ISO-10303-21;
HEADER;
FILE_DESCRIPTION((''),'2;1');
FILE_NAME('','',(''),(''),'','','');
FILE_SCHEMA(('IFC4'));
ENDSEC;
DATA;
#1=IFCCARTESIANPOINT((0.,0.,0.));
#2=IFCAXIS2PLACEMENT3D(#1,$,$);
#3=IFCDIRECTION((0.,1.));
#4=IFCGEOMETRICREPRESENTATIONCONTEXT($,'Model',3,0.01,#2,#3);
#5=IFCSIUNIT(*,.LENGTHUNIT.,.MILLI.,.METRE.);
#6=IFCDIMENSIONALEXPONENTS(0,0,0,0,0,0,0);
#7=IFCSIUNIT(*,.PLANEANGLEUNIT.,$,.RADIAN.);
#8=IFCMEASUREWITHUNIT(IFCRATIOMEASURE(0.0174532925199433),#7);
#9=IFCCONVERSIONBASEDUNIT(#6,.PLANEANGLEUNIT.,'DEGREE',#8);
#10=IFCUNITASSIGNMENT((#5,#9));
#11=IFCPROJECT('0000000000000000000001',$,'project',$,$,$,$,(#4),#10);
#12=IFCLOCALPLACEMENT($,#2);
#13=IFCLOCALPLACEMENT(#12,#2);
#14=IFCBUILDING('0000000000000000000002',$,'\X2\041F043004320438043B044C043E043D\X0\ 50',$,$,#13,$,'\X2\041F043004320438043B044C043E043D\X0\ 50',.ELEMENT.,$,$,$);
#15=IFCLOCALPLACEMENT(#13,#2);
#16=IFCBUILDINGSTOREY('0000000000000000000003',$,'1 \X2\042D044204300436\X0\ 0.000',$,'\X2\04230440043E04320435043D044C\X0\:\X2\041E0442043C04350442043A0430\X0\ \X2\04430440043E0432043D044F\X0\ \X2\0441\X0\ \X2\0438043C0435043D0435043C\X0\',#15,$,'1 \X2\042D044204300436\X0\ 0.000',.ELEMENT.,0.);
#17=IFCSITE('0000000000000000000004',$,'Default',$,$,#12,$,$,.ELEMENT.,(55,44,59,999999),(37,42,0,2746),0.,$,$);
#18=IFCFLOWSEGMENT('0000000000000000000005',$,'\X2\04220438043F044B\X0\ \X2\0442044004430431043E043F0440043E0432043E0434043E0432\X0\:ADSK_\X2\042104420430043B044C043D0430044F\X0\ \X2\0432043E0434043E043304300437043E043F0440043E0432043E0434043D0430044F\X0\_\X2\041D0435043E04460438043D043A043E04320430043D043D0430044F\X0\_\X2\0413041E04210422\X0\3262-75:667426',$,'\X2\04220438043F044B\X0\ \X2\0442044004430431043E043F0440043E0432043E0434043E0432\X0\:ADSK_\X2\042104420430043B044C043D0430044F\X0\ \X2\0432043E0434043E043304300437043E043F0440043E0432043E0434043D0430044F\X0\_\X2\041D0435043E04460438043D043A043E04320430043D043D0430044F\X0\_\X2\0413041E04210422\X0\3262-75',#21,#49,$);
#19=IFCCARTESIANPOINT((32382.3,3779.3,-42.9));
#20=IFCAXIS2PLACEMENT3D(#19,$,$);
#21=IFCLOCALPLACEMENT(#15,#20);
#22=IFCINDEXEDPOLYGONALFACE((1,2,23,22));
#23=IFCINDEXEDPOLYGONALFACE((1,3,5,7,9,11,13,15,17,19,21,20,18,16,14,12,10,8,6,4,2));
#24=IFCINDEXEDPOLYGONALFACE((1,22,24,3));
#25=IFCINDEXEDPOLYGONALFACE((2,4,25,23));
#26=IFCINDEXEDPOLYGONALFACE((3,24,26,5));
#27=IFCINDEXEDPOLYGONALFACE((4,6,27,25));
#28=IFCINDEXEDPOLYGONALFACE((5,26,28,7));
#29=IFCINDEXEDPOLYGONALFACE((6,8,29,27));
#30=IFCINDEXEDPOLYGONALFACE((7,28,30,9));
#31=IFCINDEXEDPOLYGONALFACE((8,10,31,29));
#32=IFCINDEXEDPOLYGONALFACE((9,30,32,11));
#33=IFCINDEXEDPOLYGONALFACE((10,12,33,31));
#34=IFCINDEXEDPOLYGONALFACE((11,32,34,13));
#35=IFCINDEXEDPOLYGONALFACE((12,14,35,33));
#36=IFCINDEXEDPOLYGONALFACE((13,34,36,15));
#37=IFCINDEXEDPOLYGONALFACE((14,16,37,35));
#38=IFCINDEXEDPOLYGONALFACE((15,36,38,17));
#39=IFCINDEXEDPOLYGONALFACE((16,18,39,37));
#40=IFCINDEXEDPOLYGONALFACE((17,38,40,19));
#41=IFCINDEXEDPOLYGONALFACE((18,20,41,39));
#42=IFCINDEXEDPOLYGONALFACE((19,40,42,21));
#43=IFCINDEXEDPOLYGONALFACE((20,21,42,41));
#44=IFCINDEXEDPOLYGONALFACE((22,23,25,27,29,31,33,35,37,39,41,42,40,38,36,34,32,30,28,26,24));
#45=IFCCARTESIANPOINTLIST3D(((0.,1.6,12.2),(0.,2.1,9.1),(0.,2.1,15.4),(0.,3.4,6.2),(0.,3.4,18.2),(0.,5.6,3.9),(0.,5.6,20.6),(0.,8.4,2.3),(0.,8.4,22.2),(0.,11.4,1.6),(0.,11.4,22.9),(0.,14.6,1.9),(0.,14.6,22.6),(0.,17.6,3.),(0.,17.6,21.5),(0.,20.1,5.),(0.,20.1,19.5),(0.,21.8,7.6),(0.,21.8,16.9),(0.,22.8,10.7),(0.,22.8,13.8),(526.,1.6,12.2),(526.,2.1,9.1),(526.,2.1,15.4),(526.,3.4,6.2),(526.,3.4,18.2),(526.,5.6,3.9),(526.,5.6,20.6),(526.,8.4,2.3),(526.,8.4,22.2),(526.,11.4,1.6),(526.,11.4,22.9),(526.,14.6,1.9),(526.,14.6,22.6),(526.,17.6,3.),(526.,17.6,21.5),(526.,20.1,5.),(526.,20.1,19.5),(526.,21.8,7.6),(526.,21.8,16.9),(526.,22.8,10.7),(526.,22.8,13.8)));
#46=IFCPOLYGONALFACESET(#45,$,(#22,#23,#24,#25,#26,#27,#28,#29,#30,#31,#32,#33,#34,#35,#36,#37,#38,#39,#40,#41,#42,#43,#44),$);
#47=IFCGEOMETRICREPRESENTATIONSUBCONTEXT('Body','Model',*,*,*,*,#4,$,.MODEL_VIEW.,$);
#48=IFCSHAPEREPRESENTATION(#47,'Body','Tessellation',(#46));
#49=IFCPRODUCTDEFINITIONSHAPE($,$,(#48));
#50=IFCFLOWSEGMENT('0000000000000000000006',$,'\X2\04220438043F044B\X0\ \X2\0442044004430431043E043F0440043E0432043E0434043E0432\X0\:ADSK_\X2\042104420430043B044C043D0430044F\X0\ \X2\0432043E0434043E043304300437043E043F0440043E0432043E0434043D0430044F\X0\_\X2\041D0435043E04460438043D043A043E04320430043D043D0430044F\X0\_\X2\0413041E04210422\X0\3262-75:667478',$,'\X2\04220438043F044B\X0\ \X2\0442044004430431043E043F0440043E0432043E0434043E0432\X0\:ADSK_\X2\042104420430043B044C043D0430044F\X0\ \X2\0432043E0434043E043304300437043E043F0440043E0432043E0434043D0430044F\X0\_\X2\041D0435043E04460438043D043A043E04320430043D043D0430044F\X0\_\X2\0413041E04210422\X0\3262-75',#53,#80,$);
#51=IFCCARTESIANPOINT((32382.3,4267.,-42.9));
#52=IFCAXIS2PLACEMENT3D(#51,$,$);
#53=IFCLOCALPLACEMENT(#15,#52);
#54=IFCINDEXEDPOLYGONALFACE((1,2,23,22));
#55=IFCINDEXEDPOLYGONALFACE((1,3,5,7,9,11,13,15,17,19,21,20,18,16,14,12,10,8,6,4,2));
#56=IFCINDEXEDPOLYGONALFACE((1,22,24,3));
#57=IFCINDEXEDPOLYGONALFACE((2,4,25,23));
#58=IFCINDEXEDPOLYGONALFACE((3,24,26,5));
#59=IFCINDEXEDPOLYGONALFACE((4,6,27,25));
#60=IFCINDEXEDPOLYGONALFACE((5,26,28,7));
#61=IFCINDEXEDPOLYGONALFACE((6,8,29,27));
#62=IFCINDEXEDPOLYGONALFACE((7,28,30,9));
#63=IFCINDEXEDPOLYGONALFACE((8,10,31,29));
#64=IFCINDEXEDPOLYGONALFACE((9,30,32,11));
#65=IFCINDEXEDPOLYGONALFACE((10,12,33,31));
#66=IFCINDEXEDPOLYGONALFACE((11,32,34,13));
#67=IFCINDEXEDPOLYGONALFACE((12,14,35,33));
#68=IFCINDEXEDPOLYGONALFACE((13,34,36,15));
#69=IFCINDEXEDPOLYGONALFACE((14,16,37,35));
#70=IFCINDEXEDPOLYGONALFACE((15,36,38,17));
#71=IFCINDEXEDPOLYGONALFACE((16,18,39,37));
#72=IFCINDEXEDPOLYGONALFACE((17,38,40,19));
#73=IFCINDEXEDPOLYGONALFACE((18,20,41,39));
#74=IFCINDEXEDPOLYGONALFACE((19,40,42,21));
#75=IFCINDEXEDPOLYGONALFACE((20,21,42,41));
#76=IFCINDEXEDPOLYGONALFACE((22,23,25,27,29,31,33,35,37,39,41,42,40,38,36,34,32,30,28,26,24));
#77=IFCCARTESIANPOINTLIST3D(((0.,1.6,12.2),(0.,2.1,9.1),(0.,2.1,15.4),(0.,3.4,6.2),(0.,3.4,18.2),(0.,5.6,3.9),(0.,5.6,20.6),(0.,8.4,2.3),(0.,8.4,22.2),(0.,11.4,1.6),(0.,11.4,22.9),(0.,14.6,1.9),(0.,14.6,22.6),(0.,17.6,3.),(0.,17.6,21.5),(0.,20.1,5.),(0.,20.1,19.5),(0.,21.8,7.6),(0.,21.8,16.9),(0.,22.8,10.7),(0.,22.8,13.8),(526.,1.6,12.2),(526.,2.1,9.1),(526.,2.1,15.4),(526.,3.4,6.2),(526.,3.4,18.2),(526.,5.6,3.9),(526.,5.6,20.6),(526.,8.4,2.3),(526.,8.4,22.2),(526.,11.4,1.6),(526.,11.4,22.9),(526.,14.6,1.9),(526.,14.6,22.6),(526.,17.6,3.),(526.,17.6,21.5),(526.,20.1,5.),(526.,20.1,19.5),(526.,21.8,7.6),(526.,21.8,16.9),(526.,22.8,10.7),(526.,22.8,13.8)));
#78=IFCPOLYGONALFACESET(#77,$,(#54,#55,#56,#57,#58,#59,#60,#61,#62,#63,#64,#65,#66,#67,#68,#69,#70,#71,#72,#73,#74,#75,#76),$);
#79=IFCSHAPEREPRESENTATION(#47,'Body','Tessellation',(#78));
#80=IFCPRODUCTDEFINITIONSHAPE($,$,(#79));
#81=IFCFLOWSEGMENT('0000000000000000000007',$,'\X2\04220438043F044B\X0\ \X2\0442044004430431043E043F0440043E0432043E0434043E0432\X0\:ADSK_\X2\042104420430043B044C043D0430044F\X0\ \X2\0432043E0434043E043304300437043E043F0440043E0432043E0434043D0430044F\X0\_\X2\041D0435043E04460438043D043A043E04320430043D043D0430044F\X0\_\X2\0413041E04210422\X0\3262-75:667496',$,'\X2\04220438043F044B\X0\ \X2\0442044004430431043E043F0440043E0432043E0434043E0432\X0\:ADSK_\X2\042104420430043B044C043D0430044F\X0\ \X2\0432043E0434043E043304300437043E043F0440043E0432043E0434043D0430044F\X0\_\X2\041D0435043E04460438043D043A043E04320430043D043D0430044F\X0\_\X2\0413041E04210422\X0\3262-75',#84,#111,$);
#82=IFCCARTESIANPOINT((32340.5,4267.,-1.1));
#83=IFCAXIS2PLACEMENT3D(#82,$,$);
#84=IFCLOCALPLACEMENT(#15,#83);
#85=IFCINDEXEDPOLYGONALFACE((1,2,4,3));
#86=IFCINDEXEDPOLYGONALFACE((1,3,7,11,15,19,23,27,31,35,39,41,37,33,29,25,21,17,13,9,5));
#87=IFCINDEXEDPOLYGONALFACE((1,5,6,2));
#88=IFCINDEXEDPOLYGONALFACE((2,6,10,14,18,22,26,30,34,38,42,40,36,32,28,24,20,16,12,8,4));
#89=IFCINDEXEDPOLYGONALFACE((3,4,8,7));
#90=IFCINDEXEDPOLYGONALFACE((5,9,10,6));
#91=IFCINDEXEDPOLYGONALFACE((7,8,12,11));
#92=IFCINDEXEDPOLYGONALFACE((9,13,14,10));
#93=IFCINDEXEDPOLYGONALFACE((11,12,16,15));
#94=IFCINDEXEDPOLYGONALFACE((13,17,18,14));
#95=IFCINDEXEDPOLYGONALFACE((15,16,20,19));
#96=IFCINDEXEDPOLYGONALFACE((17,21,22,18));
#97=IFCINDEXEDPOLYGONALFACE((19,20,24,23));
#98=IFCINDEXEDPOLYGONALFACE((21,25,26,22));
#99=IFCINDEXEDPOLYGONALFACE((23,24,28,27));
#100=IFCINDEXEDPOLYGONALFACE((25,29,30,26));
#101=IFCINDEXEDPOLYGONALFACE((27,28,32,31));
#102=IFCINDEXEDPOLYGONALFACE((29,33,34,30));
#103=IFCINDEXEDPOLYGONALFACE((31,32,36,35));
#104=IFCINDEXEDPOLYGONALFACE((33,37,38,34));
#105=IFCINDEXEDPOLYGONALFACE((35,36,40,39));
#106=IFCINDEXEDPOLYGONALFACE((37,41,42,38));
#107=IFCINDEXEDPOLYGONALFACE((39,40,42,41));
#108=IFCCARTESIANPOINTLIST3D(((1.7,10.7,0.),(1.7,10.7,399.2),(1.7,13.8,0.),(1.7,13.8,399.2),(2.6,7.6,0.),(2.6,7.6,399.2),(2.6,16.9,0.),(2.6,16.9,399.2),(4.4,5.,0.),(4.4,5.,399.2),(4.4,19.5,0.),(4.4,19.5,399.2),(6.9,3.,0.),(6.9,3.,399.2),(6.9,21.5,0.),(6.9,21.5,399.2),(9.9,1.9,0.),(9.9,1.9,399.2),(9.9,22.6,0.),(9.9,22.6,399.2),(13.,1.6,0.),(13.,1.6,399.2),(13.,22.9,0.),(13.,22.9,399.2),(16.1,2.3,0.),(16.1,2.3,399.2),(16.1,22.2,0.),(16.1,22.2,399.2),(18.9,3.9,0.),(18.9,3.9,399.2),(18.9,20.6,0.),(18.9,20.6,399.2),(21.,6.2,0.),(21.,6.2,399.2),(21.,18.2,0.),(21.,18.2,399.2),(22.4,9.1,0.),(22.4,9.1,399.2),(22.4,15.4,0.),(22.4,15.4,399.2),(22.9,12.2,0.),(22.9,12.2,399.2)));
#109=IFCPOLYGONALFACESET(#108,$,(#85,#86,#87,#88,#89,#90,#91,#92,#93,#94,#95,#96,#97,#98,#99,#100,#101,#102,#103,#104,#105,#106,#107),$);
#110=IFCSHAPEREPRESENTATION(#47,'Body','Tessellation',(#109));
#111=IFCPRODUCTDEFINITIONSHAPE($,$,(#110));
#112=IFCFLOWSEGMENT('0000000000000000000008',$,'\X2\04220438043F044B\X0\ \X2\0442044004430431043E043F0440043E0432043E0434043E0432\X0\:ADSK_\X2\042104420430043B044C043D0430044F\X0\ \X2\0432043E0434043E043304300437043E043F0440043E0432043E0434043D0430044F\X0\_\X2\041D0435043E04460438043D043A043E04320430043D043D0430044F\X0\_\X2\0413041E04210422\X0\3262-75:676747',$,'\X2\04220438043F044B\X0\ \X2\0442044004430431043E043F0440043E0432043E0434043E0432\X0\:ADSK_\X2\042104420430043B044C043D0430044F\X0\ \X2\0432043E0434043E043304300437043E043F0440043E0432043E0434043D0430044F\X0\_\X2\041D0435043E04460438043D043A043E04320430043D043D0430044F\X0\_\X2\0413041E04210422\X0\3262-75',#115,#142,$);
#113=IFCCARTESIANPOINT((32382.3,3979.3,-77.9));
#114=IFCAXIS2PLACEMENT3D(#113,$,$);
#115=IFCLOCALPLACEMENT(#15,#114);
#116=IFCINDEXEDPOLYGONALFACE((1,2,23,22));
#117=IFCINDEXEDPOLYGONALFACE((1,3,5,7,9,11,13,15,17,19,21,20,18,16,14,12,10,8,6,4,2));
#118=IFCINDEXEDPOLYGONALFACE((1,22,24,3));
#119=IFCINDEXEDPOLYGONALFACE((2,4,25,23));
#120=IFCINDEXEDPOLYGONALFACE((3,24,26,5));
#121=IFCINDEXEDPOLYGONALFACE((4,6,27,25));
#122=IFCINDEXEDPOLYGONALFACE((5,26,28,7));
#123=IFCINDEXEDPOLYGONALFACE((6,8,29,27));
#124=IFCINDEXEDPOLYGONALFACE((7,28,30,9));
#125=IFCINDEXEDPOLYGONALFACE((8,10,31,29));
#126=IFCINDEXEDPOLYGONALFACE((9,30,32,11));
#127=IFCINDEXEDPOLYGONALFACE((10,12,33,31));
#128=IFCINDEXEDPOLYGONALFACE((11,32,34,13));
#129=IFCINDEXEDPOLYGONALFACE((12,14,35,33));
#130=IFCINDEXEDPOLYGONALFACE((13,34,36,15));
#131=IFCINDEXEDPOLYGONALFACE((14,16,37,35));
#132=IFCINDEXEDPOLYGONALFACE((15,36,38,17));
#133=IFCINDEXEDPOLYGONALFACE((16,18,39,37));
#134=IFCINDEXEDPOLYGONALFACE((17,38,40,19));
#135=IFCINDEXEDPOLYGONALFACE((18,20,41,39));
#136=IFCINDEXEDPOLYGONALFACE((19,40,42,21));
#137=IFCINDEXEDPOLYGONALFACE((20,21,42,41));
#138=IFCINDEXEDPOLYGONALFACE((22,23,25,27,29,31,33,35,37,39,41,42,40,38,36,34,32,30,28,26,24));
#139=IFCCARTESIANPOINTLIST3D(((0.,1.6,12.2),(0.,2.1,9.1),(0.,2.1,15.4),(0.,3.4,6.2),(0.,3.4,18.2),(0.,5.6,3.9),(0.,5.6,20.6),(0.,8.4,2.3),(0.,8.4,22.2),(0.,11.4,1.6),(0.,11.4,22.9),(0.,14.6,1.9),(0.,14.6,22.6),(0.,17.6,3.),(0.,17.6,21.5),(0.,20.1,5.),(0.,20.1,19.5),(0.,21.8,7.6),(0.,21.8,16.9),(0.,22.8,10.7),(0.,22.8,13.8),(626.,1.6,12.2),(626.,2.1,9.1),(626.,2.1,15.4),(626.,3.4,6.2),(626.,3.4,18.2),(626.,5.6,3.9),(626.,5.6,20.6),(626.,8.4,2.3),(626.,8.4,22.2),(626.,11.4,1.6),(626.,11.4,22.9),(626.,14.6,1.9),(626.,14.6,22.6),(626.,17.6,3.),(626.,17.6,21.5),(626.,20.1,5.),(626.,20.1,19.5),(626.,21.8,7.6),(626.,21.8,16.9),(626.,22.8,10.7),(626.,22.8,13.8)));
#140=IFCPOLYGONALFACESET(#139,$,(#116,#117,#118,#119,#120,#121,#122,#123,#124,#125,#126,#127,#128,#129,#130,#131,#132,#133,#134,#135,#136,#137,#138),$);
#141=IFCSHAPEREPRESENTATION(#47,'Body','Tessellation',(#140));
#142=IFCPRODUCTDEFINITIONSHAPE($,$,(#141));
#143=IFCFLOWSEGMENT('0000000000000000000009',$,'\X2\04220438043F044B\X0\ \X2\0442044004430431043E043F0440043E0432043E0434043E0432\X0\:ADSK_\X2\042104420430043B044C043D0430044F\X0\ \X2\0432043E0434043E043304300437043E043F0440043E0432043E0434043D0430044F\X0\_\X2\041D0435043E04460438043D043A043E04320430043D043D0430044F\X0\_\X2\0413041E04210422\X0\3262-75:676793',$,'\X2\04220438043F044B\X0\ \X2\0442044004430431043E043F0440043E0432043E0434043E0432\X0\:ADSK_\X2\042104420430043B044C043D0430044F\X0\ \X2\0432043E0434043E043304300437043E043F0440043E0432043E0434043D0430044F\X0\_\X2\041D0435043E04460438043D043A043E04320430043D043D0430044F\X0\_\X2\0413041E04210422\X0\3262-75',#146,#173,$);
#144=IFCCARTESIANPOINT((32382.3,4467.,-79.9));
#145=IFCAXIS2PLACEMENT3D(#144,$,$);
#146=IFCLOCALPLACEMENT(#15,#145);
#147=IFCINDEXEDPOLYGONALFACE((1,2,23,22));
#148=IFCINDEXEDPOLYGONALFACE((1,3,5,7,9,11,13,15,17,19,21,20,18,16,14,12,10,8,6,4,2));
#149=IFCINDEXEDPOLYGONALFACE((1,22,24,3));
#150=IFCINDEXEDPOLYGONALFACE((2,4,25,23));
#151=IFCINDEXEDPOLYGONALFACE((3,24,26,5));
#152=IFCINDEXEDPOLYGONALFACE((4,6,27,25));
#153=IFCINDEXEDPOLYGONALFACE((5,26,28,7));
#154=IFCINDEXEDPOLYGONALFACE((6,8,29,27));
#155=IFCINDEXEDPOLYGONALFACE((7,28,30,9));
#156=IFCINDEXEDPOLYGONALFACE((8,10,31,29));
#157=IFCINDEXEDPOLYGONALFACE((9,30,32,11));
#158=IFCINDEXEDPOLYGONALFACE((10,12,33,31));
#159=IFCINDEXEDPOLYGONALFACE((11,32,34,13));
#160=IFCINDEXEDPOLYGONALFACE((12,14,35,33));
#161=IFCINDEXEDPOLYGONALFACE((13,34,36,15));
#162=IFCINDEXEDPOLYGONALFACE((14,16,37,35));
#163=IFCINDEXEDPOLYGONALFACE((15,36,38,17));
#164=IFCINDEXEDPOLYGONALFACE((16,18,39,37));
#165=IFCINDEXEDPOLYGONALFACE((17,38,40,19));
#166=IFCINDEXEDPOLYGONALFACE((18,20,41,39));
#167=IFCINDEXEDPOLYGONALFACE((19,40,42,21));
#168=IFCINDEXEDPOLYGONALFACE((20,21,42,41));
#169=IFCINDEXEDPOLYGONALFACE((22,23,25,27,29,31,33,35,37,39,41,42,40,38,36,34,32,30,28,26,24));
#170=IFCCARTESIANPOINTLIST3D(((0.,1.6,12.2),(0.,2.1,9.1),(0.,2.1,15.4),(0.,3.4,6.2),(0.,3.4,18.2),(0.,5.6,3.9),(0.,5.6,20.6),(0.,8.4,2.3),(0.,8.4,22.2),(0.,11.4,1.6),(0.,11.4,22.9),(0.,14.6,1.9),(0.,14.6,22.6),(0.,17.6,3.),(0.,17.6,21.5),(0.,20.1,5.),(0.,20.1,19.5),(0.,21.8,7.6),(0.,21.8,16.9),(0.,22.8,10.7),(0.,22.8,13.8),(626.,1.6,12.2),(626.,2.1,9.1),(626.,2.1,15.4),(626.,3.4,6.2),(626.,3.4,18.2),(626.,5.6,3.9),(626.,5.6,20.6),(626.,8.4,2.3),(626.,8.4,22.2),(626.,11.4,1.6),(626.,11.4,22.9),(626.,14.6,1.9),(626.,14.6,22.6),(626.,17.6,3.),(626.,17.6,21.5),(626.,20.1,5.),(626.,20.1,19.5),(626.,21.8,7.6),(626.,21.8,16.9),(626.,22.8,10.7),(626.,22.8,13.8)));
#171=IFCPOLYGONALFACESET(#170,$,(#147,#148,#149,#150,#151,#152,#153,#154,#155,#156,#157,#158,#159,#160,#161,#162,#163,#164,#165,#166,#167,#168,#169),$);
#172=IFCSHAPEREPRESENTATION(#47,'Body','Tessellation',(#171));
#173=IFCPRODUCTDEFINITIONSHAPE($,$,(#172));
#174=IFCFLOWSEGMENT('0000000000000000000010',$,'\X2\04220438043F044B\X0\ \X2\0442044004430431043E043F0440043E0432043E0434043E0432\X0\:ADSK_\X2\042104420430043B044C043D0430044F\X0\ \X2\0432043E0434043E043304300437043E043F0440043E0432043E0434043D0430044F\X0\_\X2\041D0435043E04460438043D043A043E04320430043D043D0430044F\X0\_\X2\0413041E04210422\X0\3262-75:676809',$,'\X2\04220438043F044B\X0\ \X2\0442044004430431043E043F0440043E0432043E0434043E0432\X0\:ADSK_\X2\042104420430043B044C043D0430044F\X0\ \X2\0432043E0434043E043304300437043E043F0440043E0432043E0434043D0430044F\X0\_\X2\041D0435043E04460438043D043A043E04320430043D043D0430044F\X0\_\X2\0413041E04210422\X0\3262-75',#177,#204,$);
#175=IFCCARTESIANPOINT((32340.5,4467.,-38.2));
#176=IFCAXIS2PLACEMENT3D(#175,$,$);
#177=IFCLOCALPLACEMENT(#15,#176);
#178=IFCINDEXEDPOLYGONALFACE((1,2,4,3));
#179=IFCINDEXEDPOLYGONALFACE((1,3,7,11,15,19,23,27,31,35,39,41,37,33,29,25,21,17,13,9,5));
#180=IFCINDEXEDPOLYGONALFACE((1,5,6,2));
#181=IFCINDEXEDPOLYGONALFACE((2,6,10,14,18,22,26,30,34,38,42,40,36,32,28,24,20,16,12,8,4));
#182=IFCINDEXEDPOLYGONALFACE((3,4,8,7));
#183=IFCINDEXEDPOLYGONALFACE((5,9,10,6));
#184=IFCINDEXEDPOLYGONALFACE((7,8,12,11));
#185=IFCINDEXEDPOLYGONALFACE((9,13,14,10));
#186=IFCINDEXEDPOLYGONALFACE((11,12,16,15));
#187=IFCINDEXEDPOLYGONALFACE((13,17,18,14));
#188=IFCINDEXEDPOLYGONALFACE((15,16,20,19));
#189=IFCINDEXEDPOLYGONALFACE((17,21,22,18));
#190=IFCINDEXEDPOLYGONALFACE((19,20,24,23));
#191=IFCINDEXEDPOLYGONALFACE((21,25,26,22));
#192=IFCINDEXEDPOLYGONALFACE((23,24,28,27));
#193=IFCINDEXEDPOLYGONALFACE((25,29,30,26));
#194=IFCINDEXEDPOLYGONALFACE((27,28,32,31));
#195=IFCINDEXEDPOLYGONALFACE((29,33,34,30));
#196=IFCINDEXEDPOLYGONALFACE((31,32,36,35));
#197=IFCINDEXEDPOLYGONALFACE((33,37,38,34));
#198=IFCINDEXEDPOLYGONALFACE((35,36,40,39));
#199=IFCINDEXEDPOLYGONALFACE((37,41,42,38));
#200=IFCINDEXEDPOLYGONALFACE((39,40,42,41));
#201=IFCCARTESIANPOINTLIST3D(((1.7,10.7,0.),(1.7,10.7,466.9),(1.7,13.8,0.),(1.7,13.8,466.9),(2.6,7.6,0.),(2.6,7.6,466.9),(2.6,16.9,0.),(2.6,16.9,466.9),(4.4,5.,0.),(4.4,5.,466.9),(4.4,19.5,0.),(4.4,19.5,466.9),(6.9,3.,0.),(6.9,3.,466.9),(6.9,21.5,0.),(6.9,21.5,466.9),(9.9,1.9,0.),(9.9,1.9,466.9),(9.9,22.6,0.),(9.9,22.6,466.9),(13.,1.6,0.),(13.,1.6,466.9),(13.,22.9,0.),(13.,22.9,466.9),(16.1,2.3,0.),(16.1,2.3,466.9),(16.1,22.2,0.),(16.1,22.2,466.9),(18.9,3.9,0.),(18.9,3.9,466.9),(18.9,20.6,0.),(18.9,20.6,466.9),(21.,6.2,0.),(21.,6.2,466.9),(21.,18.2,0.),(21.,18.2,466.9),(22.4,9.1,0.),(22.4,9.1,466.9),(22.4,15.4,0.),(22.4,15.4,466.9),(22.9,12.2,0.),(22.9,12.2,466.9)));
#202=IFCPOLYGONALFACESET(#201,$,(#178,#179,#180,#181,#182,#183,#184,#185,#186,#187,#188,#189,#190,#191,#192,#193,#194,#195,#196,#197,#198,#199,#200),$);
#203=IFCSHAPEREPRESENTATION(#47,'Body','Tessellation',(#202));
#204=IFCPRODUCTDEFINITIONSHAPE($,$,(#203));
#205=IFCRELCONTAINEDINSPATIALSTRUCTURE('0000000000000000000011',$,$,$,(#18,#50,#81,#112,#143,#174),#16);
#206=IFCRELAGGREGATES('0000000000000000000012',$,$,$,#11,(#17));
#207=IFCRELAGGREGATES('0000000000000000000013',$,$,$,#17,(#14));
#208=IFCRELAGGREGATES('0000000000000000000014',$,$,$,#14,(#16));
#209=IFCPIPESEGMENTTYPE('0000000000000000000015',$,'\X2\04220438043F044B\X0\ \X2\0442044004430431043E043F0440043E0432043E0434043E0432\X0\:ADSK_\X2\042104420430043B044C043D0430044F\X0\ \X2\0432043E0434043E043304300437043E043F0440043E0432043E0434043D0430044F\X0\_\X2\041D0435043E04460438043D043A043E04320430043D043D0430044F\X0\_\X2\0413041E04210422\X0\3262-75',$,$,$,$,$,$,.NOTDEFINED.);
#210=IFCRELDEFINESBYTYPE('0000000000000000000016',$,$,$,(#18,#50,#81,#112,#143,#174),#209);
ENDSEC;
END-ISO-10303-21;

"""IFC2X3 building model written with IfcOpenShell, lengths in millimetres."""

from ifc_helpers import new_model, entity, si_unit, converted_unit, direction, frame, frame_2d, origin, origin_2d_with_axis, place, context, subcontext, project, spatial, circle, extrude, type_object, element, save


model = new_model("IFC2X3")

# Units and contexts
model_context = context("Model", 3, precision=0.01, world=origin(), true_north=direction((0.0, 1.0)))
body_context = subcontext(model_context, "Body", "Model", "MODEL_VIEW")
ifc_project = project(units=[si_unit("LENGTHUNIT", "METRE", prefix="MILLI"), converted_unit("PLANEANGLEUNIT", "DEGREE", entity("IfcRatioMeasure", 0.0174532925199433), si_unit("PLANEANGLEUNIT", "RADIAN"), dimensions=[0, 0, 0, 0, 0, 0, 0])], contexts=[model_context])

# Site, building, storey
site_placement = place(None, origin())
site = spatial("IfcSite", under=ifc_project, at=site_placement, Name="Default", CompositionType="ELEMENT", RefLatitude=(55, 44, 59, 999999), RefLongitude=(37, 42, 0, 2746), RefElevation=0.0)
building_placement = place(site_placement, origin())
building = spatial("IfcBuilding", under=site, at=building_placement, Name="Павильон 50", LongName="Павильон 50", CompositionType="ELEMENT")
storey_placement = place(building_placement, origin())
storey = spatial("IfcBuildingStorey", under=building, at=storey_placement, Name="1 Этаж 0.000", ObjectType="Уровень:Отметка уровня с именем", LongName="1 Этаж 0.000", CompositionType="ELEMENT", Elevation=0.0)

# Flow segments
pipe_segment_type = type_object("IfcPipeSegmentType", Name="Типы трубопроводов:ADSK_Стальная водогазопроводная_Неоцинкованная_ГОСТ3262-75", PredefinedType="NOTDEFINED")
flow_segment_1_placement = place(storey_placement, frame((32382.3, 3779.3, -42.9)))
element("IfcFlowSegment", 1, at=flow_segment_1_placement, inside=storey, type_object=pipe_segment_type, Name="Типы трубопроводов:ADSK_Стальная водогазопроводная_Неоцинкованная_ГОСТ3262-75:667426", ObjectType="Типы трубопроводов:ADSK_Стальная водогазопроводная_Неоцинкованная_ГОСТ3262-75", context=body_context, shape_type="SweptSolid", body=[
    extrude(circle(Radius=10.7, at=frame_2d((0.0, 0.0), x_axis=(1.0, 0.0))), frame((0.0, 12.2, 12.2), z_axis=(1.0, 0.0, 0.0), x_axis=(0.0, -1.0, 0.0)), (0.0, 0.0, 1.0), 526.0),
])
flow_segment_2_placement = place(storey_placement, frame((32382.3, 4267.0, -42.9)))
element("IfcFlowSegment", 2, at=flow_segment_2_placement, inside=storey, type_object=pipe_segment_type, Name="Типы трубопроводов:ADSK_Стальная водогазопроводная_Неоцинкованная_ГОСТ3262-75:667478", ObjectType="Типы трубопроводов:ADSK_Стальная водогазопроводная_Неоцинкованная_ГОСТ3262-75", context=body_context, shape_type="SweptSolid", body=[
    extrude(circle(Radius=10.7, at=frame_2d((0.0, 0.0), x_axis=(1.0, 0.0))), frame((0.0, 12.2, 12.2), z_axis=(1.0, 0.0, 0.0), x_axis=(0.0, -1.0, 0.0)), (0.0, 0.0, 1.0), 526.0),
])
flow_segment_3_placement = place(storey_placement, frame((32340.5, 4267.0, -1.1)))
element("IfcFlowSegment", 3, at=flow_segment_3_placement, inside=storey, type_object=pipe_segment_type, Name="Типы трубопроводов:ADSK_Стальная водогазопроводная_Неоцинкованная_ГОСТ3262-75:667496", ObjectType="Типы трубопроводов:ADSK_Стальная водогазопроводная_Неоцинкованная_ГОСТ3262-75", context=body_context, shape_type="SweptSolid", body=[
    extrude(circle(Radius=10.7, at=origin_2d_with_axis()), frame((12.2, 12.2, 0.0)), (0.0, 0.0, 1.0), 399.2),
])
flow_segment_4_placement = place(storey_placement, frame((32382.3, 3979.3, -77.9)))
element("IfcFlowSegment", 4, at=flow_segment_4_placement, inside=storey, type_object=pipe_segment_type, Name="Типы трубопроводов:ADSK_Стальная водогазопроводная_Неоцинкованная_ГОСТ3262-75:676747", ObjectType="Типы трубопроводов:ADSK_Стальная водогазопроводная_Неоцинкованная_ГОСТ3262-75", context=body_context, shape_type="SweptSolid", body=[
    extrude(circle(Radius=10.7, at=frame_2d((0.0, 0.0), x_axis=(1.0, 0.0))), frame((0.0, 12.2, 12.2), z_axis=(1.0, 0.0, 0.0), x_axis=(0.0, -1.0, 0.0)), (0.0, 0.0, 1.0), 626.0),
])
flow_segment_5_placement = place(storey_placement, frame((32382.3, 4467.0, -79.9)))
element("IfcFlowSegment", 5, at=flow_segment_5_placement, inside=storey, type_object=pipe_segment_type, Name="Типы трубопроводов:ADSK_Стальная водогазопроводная_Неоцинкованная_ГОСТ3262-75:676793", ObjectType="Типы трубопроводов:ADSK_Стальная водогазопроводная_Неоцинкованная_ГОСТ3262-75", context=body_context, shape_type="SweptSolid", body=[
    extrude(circle(Radius=10.7, at=frame_2d((0.0, 0.0), x_axis=(1.0, 0.0))), frame((0.0, 12.2, 12.2), z_axis=(1.0, 0.0, 0.0), x_axis=(0.0, -1.0, 0.0)), (0.0, 0.0, 1.0), 626.0),
])
flow_segment_6_placement = place(storey_placement, frame((32340.5, 4467.0, -38.2)))
element("IfcFlowSegment", 6, at=flow_segment_6_placement, inside=storey, type_object=pipe_segment_type, Name="Типы трубопроводов:ADSK_Стальная водогазопроводная_Неоцинкованная_ГОСТ3262-75:676809", ObjectType="Типы трубопроводов:ADSK_Стальная водогазопроводная_Неоцинкованная_ГОСТ3262-75", context=body_context, shape_type="SweptSolid", body=[
    extrude(circle(Radius=10.7, at=origin_2d_with_axis()), frame((12.2, 12.2, 0.0)), (0.0, 0.0, 1.0), 466.9),
])

save(model, "model.ifc")
